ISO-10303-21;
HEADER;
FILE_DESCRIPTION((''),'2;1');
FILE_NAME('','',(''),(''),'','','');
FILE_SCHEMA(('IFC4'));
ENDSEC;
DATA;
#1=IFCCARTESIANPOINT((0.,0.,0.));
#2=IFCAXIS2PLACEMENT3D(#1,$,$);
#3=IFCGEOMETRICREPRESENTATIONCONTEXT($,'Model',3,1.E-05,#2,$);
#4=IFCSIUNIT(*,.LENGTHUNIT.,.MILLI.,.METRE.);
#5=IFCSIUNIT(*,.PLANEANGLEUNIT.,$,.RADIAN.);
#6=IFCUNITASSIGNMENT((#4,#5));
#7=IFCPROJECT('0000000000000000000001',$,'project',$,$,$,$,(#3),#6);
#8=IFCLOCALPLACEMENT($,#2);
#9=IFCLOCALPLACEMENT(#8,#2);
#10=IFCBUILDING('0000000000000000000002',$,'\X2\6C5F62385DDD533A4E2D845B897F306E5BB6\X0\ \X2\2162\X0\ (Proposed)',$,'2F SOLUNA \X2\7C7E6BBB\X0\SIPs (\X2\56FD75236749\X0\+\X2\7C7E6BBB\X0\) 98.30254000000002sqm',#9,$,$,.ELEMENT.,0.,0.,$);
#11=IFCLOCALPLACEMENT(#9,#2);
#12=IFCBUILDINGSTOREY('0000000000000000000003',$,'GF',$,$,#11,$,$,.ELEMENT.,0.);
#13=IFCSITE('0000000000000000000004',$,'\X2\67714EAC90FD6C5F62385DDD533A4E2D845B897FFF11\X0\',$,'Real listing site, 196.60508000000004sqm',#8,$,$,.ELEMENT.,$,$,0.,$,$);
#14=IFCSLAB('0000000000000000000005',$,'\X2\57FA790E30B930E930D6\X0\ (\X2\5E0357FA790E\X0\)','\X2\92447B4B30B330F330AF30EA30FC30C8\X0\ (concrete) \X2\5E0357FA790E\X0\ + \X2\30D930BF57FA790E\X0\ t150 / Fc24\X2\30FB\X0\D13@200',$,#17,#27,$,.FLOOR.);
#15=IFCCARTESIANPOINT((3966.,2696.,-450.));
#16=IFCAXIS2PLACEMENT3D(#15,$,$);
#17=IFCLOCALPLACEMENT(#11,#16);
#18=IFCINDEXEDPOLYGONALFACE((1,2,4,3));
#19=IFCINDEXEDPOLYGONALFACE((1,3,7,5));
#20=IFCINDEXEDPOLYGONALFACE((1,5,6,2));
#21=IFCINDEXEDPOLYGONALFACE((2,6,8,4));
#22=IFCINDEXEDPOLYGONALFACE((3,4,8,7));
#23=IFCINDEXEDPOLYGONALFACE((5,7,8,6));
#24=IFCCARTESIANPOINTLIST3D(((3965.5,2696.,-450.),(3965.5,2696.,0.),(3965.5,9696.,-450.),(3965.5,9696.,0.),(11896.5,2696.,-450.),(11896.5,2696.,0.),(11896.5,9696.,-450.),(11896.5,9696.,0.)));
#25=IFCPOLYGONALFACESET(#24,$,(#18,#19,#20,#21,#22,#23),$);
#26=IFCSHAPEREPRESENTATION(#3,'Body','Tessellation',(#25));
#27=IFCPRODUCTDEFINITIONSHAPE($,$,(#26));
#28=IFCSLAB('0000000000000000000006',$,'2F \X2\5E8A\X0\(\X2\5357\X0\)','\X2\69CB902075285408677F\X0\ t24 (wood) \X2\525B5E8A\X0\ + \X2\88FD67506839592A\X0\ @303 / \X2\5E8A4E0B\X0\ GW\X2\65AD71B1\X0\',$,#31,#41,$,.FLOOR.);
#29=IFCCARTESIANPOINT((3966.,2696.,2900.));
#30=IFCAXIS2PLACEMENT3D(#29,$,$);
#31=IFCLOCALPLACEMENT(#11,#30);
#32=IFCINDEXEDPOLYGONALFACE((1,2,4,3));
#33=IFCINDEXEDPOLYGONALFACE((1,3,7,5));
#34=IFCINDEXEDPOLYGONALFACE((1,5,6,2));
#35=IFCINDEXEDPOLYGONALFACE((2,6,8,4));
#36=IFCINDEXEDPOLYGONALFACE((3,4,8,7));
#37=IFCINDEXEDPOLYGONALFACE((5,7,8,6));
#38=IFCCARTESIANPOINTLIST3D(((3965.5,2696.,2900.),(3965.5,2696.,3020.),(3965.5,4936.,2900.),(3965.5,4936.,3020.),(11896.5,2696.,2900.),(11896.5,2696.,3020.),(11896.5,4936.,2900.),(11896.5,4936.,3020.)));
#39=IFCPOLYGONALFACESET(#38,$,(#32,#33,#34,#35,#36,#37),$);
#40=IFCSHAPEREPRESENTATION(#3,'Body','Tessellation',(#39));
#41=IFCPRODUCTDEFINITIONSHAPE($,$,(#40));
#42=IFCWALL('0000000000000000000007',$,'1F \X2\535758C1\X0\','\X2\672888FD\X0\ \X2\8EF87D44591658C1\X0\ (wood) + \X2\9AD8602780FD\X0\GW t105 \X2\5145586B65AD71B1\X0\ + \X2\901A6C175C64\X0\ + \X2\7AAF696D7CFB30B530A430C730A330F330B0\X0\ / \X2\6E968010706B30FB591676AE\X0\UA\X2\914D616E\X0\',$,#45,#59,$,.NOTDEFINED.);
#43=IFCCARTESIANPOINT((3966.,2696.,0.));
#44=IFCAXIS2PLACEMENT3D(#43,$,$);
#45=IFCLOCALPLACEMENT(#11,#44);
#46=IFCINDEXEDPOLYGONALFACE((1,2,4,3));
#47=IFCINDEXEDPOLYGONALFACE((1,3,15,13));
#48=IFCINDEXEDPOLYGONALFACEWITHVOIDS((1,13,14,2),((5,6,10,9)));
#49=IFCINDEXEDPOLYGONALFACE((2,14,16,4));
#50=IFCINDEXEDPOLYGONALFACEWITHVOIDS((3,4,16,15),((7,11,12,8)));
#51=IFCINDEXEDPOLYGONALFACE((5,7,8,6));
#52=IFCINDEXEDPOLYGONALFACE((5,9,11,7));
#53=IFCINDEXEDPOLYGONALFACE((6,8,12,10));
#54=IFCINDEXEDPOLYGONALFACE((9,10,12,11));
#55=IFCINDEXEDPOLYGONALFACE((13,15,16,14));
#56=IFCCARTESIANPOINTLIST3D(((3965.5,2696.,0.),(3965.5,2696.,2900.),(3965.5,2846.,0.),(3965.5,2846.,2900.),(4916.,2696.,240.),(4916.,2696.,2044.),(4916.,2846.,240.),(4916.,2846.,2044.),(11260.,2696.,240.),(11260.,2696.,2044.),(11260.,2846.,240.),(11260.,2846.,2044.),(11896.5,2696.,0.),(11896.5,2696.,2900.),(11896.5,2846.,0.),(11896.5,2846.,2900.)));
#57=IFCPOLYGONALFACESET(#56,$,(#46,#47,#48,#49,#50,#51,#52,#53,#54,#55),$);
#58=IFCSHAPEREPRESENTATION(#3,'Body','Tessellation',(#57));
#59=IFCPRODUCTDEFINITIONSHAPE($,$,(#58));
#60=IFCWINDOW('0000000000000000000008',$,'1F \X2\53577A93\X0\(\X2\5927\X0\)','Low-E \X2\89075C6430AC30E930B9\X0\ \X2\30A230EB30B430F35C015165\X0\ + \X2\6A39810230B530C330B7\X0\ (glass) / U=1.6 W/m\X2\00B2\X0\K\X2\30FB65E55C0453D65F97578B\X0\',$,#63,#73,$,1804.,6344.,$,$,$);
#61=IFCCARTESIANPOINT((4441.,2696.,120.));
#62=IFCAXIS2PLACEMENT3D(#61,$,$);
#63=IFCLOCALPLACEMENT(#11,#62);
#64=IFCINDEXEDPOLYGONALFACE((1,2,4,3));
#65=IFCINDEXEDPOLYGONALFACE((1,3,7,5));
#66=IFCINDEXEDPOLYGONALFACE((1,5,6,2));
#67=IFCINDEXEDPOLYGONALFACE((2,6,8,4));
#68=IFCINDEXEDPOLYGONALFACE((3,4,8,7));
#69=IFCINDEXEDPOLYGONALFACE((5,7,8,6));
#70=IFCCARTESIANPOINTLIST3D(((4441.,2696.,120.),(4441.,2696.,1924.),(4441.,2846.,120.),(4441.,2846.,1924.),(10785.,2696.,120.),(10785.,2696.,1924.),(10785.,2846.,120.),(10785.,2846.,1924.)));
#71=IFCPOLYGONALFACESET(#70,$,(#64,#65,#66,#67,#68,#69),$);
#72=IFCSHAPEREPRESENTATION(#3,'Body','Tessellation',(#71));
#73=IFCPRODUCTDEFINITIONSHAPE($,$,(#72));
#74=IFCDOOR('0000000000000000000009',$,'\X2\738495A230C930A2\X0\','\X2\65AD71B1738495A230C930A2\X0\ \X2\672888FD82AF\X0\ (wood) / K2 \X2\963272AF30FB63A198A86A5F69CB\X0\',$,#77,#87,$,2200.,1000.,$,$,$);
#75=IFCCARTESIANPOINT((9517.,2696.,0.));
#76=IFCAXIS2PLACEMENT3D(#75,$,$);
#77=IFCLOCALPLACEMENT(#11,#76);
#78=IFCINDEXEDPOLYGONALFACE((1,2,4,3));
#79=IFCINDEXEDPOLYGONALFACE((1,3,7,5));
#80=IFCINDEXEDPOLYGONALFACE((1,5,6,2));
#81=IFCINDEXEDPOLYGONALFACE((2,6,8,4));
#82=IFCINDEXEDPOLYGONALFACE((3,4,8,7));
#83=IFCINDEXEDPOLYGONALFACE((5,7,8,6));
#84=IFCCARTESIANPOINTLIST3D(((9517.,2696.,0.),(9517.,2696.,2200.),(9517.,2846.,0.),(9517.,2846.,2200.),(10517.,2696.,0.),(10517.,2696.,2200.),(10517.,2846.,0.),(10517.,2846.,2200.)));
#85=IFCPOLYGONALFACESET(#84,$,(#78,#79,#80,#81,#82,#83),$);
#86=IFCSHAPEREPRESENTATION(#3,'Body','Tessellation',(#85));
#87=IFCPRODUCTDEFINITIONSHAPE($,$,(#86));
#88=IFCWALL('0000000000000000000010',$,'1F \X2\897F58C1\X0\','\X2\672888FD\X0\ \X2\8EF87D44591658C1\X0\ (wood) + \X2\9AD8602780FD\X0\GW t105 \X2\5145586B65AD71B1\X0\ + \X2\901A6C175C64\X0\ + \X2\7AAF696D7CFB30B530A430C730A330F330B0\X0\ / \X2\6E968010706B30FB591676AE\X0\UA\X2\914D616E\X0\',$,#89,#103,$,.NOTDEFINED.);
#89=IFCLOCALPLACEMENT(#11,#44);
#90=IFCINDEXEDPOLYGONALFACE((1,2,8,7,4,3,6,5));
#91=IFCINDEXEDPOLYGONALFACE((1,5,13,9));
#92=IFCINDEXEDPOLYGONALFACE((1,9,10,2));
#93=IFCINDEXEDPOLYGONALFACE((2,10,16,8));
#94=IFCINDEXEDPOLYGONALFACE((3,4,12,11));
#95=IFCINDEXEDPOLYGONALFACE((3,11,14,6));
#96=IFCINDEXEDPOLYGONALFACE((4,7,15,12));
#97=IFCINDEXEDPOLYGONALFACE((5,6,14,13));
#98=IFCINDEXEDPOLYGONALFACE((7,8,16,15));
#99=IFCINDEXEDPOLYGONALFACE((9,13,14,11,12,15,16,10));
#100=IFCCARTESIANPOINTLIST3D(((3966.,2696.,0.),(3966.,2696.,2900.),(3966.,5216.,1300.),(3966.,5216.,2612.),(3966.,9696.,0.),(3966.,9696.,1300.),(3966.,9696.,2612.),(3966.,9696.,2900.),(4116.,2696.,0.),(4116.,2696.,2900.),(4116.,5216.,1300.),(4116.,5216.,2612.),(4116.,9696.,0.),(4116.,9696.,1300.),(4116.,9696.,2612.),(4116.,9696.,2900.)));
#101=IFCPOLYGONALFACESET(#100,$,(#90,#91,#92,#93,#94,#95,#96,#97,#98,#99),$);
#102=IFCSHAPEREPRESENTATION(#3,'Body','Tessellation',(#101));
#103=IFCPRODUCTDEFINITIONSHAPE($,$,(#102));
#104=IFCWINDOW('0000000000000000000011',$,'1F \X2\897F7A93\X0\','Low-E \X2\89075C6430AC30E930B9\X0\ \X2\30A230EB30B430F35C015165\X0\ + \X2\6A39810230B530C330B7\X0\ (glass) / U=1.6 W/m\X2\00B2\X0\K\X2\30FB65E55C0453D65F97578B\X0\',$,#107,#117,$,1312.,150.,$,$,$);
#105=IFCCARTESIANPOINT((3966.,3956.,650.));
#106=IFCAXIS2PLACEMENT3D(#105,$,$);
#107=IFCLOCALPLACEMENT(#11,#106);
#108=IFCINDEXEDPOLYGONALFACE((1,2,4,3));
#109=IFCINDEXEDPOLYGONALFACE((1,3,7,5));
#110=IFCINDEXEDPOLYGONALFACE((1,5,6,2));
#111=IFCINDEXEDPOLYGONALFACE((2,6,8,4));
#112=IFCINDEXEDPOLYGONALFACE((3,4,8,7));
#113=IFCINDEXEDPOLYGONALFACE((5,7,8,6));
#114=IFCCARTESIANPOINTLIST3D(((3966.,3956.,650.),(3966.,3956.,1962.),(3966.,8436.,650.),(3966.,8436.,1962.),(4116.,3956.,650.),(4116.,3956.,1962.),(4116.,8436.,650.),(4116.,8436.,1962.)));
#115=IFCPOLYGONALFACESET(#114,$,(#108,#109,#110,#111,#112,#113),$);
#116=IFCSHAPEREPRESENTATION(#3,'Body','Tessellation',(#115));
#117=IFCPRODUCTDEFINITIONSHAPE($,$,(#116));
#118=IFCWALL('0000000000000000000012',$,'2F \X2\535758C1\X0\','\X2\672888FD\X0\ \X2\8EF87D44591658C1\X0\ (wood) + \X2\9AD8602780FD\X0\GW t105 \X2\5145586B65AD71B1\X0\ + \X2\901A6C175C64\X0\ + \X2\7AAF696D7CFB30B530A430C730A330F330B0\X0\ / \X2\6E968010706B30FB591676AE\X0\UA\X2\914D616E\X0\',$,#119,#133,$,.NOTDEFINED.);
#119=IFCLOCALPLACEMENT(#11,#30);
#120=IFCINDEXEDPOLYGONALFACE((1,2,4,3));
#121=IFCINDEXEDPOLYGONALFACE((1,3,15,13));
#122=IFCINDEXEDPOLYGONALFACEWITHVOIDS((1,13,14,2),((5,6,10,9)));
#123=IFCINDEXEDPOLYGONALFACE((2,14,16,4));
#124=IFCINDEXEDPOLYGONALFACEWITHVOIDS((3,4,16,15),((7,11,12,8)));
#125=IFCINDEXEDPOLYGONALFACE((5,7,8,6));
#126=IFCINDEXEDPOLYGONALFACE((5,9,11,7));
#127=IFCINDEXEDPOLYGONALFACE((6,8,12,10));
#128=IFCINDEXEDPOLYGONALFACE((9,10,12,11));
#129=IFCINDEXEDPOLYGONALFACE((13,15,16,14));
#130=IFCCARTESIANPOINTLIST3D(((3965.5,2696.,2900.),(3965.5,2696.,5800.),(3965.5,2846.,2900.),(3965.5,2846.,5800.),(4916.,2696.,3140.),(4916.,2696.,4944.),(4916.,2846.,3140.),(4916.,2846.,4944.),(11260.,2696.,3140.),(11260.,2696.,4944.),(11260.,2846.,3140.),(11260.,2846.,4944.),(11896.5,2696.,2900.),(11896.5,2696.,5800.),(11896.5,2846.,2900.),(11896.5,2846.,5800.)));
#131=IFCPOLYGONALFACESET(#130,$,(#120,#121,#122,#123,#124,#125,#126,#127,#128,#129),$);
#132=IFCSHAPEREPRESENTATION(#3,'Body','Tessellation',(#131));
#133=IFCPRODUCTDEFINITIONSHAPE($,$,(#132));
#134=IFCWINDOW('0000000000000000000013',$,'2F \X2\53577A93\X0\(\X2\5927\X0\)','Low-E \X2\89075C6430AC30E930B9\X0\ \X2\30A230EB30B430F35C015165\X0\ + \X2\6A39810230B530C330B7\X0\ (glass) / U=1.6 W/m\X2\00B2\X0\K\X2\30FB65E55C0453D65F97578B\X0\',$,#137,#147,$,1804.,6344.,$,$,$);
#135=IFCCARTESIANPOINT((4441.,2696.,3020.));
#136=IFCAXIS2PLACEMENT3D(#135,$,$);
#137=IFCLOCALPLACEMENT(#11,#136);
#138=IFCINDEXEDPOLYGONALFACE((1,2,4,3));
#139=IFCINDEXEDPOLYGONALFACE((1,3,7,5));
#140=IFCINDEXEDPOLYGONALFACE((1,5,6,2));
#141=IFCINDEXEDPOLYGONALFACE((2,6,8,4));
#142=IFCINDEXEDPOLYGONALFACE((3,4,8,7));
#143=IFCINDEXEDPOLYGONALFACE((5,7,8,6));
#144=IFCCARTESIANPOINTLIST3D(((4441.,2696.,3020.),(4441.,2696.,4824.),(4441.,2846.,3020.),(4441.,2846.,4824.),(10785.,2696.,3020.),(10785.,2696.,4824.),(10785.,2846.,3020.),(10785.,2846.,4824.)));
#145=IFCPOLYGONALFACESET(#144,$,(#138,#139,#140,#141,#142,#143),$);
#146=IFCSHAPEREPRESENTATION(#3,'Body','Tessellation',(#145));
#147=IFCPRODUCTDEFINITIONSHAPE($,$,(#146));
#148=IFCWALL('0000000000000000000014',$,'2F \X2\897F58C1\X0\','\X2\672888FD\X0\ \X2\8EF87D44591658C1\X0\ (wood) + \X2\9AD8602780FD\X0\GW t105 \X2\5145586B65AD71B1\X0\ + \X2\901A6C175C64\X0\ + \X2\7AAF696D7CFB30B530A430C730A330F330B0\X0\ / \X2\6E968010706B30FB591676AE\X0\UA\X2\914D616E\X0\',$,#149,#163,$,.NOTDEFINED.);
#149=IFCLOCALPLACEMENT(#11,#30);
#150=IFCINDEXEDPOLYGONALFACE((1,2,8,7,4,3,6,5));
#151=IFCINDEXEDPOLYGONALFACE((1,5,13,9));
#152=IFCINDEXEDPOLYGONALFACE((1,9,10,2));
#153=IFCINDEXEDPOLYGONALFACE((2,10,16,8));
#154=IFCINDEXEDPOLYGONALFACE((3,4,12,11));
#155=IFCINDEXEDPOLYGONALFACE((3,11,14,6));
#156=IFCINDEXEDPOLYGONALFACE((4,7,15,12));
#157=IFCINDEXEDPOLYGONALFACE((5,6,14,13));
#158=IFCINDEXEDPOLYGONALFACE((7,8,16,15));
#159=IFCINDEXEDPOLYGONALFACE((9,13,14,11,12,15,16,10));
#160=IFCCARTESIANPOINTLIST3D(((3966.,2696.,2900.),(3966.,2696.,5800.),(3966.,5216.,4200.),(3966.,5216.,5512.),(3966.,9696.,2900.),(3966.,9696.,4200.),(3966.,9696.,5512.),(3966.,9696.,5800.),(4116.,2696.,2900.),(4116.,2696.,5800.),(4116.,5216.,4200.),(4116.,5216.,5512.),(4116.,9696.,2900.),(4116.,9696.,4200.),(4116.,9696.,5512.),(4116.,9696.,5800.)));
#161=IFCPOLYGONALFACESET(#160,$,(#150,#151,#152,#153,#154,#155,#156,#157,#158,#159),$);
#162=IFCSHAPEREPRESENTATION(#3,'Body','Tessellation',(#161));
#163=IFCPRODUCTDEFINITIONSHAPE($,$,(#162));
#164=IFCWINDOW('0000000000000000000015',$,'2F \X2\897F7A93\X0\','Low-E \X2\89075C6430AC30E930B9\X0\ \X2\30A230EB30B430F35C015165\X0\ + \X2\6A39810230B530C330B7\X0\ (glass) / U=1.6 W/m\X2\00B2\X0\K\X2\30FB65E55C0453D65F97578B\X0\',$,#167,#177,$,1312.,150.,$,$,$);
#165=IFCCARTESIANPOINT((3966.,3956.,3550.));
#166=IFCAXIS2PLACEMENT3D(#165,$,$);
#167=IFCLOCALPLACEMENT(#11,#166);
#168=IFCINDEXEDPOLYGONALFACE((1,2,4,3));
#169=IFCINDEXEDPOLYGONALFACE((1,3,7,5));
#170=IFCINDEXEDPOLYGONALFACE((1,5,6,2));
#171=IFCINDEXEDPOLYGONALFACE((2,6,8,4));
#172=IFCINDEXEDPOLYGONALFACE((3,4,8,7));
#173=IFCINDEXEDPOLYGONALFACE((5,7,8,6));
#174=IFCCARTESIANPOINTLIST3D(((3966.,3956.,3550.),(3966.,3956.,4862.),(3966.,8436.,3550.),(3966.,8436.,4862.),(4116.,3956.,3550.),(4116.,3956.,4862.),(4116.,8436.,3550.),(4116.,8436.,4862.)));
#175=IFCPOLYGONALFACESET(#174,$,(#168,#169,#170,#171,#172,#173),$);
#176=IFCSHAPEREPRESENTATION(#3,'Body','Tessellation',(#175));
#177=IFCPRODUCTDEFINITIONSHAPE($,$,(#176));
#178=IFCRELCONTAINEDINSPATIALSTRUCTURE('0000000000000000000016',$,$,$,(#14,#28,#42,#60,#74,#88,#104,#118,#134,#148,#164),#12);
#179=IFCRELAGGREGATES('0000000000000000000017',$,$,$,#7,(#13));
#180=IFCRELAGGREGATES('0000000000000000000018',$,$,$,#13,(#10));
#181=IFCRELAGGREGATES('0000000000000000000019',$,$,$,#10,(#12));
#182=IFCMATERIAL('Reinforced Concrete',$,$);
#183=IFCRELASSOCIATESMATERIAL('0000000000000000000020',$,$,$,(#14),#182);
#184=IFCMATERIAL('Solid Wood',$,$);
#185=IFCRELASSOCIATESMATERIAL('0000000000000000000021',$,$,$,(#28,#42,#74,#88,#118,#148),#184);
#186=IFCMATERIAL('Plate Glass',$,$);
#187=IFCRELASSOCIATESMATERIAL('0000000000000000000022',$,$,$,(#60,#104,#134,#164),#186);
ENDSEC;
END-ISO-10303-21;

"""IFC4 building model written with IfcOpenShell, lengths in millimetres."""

from ifc_helpers import new_model, si_unit, frame, frame_2d, origin, place, context, project, spatial, rectangle, extrude, material, element, fill, save


model = new_model("IFC4")

# Units and contexts
model_context = context("Model", 3, precision=1e-05, world=origin())
ifc_project = project(units=[si_unit("LENGTHUNIT", "METRE", prefix="MILLI"), si_unit("PLANEANGLEUNIT", "RADIAN")], contexts=[model_context])

# Site, building, storey
site_placement = place(None, origin())
site = spatial("IfcSite", under=ifc_project, at=site_placement, Name="東京都江戸川区中葛西１", ObjectType="Real listing site, 196.60508000000004sqm", CompositionType="ELEMENT", RefElevation=0.0)
building_placement = place(site_placement, origin())
building = spatial("IfcBuilding", under=site, at=building_placement, Name="江戸川区中葛西の家 Ⅲ (Proposed)", ObjectType="2F SOLUNA 籾殻SIPs (国産杉+籾殻) 98.30254000000002sqm", CompositionType="ELEMENT", ElevationOfRefHeight=0.0, ElevationOfTerrain=0.0)
storey_placement = place(building_placement, origin())
storey = spatial("IfcBuildingStorey", under=building, at=storey_placement, Name="GF", CompositionType="ELEMENT", Elevation=0.0)

# Slabs
ifc_material_1 = material(Name="Reinforced Concrete")
slab_1_placement = place(storey_placement, frame((3966.0, 2696.0, -450.0)))
element("IfcSlab", 1, at=slab_1_placement, inside=storey, material=ifc_material_1, Name="基礎スラブ (布基礎)", Description="鉄筋コンクリート (concrete) 布基礎 + ベタ基礎 t150 / Fc24・D13@200", PredefinedType="FLOOR", context=model_context, shape_type="SweptSolid", body=[
    extrude(rectangle(XDim=7931.0, YDim=7000.0, at=frame_2d((3965.0, 3500.0))), frame((3966.0, 2696.0, -450.0)), (0.0, 0.0, 1.0), 450.0),
])
ifc_material_2 = material(Name="Solid Wood")
slab_2_placement = place(storey_placement, frame((3966.0, 2696.0, 2900.0)))
element("IfcSlab", 2, at=slab_2_placement, inside=storey, material=ifc_material_2, Name="2F 床(南)", Description="構造用合板 t24 (wood) 剛床 + 製材根太 @303 / 床下 GW断熱", PredefinedType="FLOOR", context=model_context, shape_type="SweptSolid", body=[
    extrude(rectangle(XDim=7931.0, YDim=2240.0, at=frame_2d((3965.0, 1120.0))), frame((3966.0, 2696.0, 2900.0)), (0.0, 0.0, 1.0), 120.0),
])

# Wall, openings, window, door
wall_1_placement = place(storey_placement, frame((3966.0, 2696.0, 0.0)))
wall_1 = element("IfcWall", 3, at=wall_1_placement, inside=storey, material=ifc_material_2, Name="1F 南壁", Description="木製 軸組外壁 (wood) + 高性能GW t105 充填断熱 + 通気層 + 窯業系サイディング / 準耐火・外皮UA配慮", PredefinedType="NOTDEFINED", context=model_context, shape_type="SweptSolid", body=[
    extrude(rectangle(XDim=7931.0, YDim=150.0, at=frame_2d((3965.0, 75.0))), frame((3966.0, 2696.0, 0.0)), (0.0, 0.0, 1.0), 2900.0),
])
opening_1_placement = place(storey_placement, frame((4441.0, 2696.0, 120.0)))
opening_1 = element("IfcOpeningElement", 4, at=opening_1_placement, cuts=wall_1, PredefinedType="NOTDEFINED", context=model_context, shape_type="SweptSolid", body=[
    extrude(rectangle(XDim=6344.0, YDim=150.0, at=frame_2d((3172.0, 75.0))), frame((4441.0, 2696.0, 120.0)), (0.0, 0.0, 1.0), 1804.0),
])
opening_2_placement = place(storey_placement, frame((9517.0, 2696.0, 0.0)))
opening_2 = element("IfcOpeningElement", 5, at=opening_2_placement, cuts=wall_1, PredefinedType="NOTDEFINED", context=model_context, shape_type="SweptSolid", body=[
    extrude(rectangle(XDim=1000.0, YDim=150.0, at=frame_2d((500.0, 75.0))), frame((9517.0, 2696.0, 0.0)), (0.0, 0.0, 1.0), 2200.0),
])
ifc_material_3 = material(Name="Plate Glass")
window_1_placement = place(storey_placement, frame((4441.0, 2696.0, 120.0)))
window_1 = element("IfcWindow", 6, at=window_1_placement, inside=storey, material=ifc_material_3, Name="1F 南窓(大)", Description="Low-E 複層ガラス アルゴン封入 + 樹脂サッシ (glass) / U=1.6 W/m²K・日射取得型", OverallHeight=1804.0, OverallWidth=6344.0, context=model_context, shape_type="SweptSolid", body=[
    extrude(rectangle(XDim=6344.0, YDim=150.0, at=frame_2d((3172.0, 75.0))), frame((4441.0, 2696.0, 120.0)), (0.0, 0.0, 1.0), 1804.0),
])
fill(opening_1, window_1)
door_placement = place(storey_placement, frame((9517.0, 2696.0, 0.0)))
door = element("IfcDoor", 7, at=door_placement, inside=storey, material=ifc_material_2, Name="玄関ドア", Description="断熱玄関ドア 木製芯 (wood) / K2 防犯・採風機構", OverallHeight=2200.0, OverallWidth=1000.0, context=model_context, shape_type="SweptSolid", body=[
    extrude(rectangle(XDim=1000.0, YDim=150.0, at=frame_2d((500.0, 75.0))), frame((9517.0, 2696.0, 0.0)), (0.0, 0.0, 1.0), 2200.0),
])
fill(opening_2, door)

# Walls, openings, windows
wall_2_placement = place(storey_placement, frame((3966.0, 2696.0, 0.0)))
wall_2 = element("IfcWall", 8, at=wall_2_placement, inside=storey, material=ifc_material_2, Name="1F 西壁", Description="木製 軸組外壁 (wood) + 高性能GW t105 充填断熱 + 通気層 + 窯業系サイディング / 準耐火・外皮UA配慮", PredefinedType="NOTDEFINED", context=model_context, shape_type="SweptSolid", body=[
    extrude(rectangle(XDim=150.0, YDim=7000.0, at=frame_2d((75.0, 3500.0))), frame((3966.0, 2696.0, 0.0)), (0.0, 0.0, 1.0), 2900.0),
])
opening_3_placement = place(storey_placement, frame((3966.0, 3956.0, 650.0)))
opening_3 = element("IfcOpeningElement", 9, at=opening_3_placement, cuts=wall_2, PredefinedType="NOTDEFINED", context=model_context, shape_type="SweptSolid", body=[
    extrude(rectangle(XDim=150.0, YDim=4480.0, at=frame_2d((75.0, 2240.0))), frame((3966.0, 3956.0, 650.0)), (0.0, 0.0, 1.0), 1312.0),
])
window_2_placement = place(storey_placement, frame((3966.0, 3956.0, 650.0)))
window_2 = element("IfcWindow", 10, at=window_2_placement, inside=storey, material=ifc_material_3, Name="1F 西窓", Description="Low-E 複層ガラス アルゴン封入 + 樹脂サッシ (glass) / U=1.6 W/m²K・日射取得型", OverallHeight=1312.0, OverallWidth=150.0, context=model_context, shape_type="SweptSolid", body=[
    extrude(rectangle(XDim=150.0, YDim=4480.0, at=frame_2d((75.0, 2240.0))), frame((3966.0, 3956.0, 650.0)), (0.0, 0.0, 1.0), 1312.0),
])
fill(opening_3, window_2)
wall_3_placement = place(storey_placement, frame((3966.0, 2696.0, 2900.0)))
wall_3 = element("IfcWall", 11, at=wall_3_placement, inside=storey, material=ifc_material_2, Name="2F 南壁", Description="木製 軸組外壁 (wood) + 高性能GW t105 充填断熱 + 通気層 + 窯業系サイディング / 準耐火・外皮UA配慮", PredefinedType="NOTDEFINED", context=model_context, shape_type="SweptSolid", body=[
    extrude(rectangle(XDim=7931.0, YDim=150.0, at=frame_2d((3965.0, 75.0))), frame((3966.0, 2696.0, 2900.0)), (0.0, 0.0, 1.0), 2900.0),
])
opening_4_placement = place(storey_placement, frame((4441.0, 2696.0, 3020.0)))
opening_4 = element("IfcOpeningElement", 12, at=opening_4_placement, cuts=wall_3, PredefinedType="NOTDEFINED", context=model_context, shape_type="SweptSolid", body=[
    extrude(rectangle(XDim=6344.0, YDim=150.0, at=frame_2d((3172.0, 75.0))), frame((4441.0, 2696.0, 3020.0)), (0.0, 0.0, 1.0), 1804.0),
])
window_3_placement = place(storey_placement, frame((4441.0, 2696.0, 3020.0)))
window_3 = element("IfcWindow", 13, at=window_3_placement, inside=storey, material=ifc_material_3, Name="2F 南窓(大)", Description="Low-E 複層ガラス アルゴン封入 + 樹脂サッシ (glass) / U=1.6 W/m²K・日射取得型", OverallHeight=1804.0, OverallWidth=6344.0, context=model_context, shape_type="SweptSolid", body=[
    extrude(rectangle(XDim=6344.0, YDim=150.0, at=frame_2d((3172.0, 75.0))), frame((4441.0, 2696.0, 3020.0)), (0.0, 0.0, 1.0), 1804.0),
])
fill(opening_4, window_3)
wall_4_placement = place(storey_placement, frame((3966.0, 2696.0, 2900.0)))
wall_4 = element("IfcWall", 14, at=wall_4_placement, inside=storey, material=ifc_material_2, Name="2F 西壁", Description="木製 軸組外壁 (wood) + 高性能GW t105 充填断熱 + 通気層 + 窯業系サイディング / 準耐火・外皮UA配慮", PredefinedType="NOTDEFINED", context=model_context, shape_type="SweptSolid", body=[
    extrude(rectangle(XDim=150.0, YDim=7000.0, at=frame_2d((75.0, 3500.0))), frame((3966.0, 2696.0, 2900.0)), (0.0, 0.0, 1.0), 2900.0),
])
opening_5_placement = place(storey_placement, frame((3966.0, 3956.0, 3550.0)))
opening_5 = element("IfcOpeningElement", 15, at=opening_5_placement, cuts=wall_4, PredefinedType="NOTDEFINED", context=model_context, shape_type="SweptSolid", body=[
    extrude(rectangle(XDim=150.0, YDim=4480.0, at=frame_2d((75.0, 2240.0))), frame((3966.0, 3956.0, 3550.0)), (0.0, 0.0, 1.0), 1312.0),
])
window_4_placement = place(storey_placement, frame((3966.0, 3956.0, 3550.0)))
window_4 = element("IfcWindow", 16, at=window_4_placement, inside=storey, material=ifc_material_3, Name="2F 西窓", Description="Low-E 複層ガラス アルゴン封入 + 樹脂サッシ (glass) / U=1.6 W/m²K・日射取得型", OverallHeight=1312.0, OverallWidth=150.0, context=model_context, shape_type="SweptSolid", body=[
    extrude(rectangle(XDim=150.0, YDim=4480.0, at=frame_2d((75.0, 2240.0))), frame((3966.0, 3956.0, 3550.0)), (0.0, 0.0, 1.0), 1312.0),
])
fill(opening_5, window_4)

save(model, "model.ifc")
